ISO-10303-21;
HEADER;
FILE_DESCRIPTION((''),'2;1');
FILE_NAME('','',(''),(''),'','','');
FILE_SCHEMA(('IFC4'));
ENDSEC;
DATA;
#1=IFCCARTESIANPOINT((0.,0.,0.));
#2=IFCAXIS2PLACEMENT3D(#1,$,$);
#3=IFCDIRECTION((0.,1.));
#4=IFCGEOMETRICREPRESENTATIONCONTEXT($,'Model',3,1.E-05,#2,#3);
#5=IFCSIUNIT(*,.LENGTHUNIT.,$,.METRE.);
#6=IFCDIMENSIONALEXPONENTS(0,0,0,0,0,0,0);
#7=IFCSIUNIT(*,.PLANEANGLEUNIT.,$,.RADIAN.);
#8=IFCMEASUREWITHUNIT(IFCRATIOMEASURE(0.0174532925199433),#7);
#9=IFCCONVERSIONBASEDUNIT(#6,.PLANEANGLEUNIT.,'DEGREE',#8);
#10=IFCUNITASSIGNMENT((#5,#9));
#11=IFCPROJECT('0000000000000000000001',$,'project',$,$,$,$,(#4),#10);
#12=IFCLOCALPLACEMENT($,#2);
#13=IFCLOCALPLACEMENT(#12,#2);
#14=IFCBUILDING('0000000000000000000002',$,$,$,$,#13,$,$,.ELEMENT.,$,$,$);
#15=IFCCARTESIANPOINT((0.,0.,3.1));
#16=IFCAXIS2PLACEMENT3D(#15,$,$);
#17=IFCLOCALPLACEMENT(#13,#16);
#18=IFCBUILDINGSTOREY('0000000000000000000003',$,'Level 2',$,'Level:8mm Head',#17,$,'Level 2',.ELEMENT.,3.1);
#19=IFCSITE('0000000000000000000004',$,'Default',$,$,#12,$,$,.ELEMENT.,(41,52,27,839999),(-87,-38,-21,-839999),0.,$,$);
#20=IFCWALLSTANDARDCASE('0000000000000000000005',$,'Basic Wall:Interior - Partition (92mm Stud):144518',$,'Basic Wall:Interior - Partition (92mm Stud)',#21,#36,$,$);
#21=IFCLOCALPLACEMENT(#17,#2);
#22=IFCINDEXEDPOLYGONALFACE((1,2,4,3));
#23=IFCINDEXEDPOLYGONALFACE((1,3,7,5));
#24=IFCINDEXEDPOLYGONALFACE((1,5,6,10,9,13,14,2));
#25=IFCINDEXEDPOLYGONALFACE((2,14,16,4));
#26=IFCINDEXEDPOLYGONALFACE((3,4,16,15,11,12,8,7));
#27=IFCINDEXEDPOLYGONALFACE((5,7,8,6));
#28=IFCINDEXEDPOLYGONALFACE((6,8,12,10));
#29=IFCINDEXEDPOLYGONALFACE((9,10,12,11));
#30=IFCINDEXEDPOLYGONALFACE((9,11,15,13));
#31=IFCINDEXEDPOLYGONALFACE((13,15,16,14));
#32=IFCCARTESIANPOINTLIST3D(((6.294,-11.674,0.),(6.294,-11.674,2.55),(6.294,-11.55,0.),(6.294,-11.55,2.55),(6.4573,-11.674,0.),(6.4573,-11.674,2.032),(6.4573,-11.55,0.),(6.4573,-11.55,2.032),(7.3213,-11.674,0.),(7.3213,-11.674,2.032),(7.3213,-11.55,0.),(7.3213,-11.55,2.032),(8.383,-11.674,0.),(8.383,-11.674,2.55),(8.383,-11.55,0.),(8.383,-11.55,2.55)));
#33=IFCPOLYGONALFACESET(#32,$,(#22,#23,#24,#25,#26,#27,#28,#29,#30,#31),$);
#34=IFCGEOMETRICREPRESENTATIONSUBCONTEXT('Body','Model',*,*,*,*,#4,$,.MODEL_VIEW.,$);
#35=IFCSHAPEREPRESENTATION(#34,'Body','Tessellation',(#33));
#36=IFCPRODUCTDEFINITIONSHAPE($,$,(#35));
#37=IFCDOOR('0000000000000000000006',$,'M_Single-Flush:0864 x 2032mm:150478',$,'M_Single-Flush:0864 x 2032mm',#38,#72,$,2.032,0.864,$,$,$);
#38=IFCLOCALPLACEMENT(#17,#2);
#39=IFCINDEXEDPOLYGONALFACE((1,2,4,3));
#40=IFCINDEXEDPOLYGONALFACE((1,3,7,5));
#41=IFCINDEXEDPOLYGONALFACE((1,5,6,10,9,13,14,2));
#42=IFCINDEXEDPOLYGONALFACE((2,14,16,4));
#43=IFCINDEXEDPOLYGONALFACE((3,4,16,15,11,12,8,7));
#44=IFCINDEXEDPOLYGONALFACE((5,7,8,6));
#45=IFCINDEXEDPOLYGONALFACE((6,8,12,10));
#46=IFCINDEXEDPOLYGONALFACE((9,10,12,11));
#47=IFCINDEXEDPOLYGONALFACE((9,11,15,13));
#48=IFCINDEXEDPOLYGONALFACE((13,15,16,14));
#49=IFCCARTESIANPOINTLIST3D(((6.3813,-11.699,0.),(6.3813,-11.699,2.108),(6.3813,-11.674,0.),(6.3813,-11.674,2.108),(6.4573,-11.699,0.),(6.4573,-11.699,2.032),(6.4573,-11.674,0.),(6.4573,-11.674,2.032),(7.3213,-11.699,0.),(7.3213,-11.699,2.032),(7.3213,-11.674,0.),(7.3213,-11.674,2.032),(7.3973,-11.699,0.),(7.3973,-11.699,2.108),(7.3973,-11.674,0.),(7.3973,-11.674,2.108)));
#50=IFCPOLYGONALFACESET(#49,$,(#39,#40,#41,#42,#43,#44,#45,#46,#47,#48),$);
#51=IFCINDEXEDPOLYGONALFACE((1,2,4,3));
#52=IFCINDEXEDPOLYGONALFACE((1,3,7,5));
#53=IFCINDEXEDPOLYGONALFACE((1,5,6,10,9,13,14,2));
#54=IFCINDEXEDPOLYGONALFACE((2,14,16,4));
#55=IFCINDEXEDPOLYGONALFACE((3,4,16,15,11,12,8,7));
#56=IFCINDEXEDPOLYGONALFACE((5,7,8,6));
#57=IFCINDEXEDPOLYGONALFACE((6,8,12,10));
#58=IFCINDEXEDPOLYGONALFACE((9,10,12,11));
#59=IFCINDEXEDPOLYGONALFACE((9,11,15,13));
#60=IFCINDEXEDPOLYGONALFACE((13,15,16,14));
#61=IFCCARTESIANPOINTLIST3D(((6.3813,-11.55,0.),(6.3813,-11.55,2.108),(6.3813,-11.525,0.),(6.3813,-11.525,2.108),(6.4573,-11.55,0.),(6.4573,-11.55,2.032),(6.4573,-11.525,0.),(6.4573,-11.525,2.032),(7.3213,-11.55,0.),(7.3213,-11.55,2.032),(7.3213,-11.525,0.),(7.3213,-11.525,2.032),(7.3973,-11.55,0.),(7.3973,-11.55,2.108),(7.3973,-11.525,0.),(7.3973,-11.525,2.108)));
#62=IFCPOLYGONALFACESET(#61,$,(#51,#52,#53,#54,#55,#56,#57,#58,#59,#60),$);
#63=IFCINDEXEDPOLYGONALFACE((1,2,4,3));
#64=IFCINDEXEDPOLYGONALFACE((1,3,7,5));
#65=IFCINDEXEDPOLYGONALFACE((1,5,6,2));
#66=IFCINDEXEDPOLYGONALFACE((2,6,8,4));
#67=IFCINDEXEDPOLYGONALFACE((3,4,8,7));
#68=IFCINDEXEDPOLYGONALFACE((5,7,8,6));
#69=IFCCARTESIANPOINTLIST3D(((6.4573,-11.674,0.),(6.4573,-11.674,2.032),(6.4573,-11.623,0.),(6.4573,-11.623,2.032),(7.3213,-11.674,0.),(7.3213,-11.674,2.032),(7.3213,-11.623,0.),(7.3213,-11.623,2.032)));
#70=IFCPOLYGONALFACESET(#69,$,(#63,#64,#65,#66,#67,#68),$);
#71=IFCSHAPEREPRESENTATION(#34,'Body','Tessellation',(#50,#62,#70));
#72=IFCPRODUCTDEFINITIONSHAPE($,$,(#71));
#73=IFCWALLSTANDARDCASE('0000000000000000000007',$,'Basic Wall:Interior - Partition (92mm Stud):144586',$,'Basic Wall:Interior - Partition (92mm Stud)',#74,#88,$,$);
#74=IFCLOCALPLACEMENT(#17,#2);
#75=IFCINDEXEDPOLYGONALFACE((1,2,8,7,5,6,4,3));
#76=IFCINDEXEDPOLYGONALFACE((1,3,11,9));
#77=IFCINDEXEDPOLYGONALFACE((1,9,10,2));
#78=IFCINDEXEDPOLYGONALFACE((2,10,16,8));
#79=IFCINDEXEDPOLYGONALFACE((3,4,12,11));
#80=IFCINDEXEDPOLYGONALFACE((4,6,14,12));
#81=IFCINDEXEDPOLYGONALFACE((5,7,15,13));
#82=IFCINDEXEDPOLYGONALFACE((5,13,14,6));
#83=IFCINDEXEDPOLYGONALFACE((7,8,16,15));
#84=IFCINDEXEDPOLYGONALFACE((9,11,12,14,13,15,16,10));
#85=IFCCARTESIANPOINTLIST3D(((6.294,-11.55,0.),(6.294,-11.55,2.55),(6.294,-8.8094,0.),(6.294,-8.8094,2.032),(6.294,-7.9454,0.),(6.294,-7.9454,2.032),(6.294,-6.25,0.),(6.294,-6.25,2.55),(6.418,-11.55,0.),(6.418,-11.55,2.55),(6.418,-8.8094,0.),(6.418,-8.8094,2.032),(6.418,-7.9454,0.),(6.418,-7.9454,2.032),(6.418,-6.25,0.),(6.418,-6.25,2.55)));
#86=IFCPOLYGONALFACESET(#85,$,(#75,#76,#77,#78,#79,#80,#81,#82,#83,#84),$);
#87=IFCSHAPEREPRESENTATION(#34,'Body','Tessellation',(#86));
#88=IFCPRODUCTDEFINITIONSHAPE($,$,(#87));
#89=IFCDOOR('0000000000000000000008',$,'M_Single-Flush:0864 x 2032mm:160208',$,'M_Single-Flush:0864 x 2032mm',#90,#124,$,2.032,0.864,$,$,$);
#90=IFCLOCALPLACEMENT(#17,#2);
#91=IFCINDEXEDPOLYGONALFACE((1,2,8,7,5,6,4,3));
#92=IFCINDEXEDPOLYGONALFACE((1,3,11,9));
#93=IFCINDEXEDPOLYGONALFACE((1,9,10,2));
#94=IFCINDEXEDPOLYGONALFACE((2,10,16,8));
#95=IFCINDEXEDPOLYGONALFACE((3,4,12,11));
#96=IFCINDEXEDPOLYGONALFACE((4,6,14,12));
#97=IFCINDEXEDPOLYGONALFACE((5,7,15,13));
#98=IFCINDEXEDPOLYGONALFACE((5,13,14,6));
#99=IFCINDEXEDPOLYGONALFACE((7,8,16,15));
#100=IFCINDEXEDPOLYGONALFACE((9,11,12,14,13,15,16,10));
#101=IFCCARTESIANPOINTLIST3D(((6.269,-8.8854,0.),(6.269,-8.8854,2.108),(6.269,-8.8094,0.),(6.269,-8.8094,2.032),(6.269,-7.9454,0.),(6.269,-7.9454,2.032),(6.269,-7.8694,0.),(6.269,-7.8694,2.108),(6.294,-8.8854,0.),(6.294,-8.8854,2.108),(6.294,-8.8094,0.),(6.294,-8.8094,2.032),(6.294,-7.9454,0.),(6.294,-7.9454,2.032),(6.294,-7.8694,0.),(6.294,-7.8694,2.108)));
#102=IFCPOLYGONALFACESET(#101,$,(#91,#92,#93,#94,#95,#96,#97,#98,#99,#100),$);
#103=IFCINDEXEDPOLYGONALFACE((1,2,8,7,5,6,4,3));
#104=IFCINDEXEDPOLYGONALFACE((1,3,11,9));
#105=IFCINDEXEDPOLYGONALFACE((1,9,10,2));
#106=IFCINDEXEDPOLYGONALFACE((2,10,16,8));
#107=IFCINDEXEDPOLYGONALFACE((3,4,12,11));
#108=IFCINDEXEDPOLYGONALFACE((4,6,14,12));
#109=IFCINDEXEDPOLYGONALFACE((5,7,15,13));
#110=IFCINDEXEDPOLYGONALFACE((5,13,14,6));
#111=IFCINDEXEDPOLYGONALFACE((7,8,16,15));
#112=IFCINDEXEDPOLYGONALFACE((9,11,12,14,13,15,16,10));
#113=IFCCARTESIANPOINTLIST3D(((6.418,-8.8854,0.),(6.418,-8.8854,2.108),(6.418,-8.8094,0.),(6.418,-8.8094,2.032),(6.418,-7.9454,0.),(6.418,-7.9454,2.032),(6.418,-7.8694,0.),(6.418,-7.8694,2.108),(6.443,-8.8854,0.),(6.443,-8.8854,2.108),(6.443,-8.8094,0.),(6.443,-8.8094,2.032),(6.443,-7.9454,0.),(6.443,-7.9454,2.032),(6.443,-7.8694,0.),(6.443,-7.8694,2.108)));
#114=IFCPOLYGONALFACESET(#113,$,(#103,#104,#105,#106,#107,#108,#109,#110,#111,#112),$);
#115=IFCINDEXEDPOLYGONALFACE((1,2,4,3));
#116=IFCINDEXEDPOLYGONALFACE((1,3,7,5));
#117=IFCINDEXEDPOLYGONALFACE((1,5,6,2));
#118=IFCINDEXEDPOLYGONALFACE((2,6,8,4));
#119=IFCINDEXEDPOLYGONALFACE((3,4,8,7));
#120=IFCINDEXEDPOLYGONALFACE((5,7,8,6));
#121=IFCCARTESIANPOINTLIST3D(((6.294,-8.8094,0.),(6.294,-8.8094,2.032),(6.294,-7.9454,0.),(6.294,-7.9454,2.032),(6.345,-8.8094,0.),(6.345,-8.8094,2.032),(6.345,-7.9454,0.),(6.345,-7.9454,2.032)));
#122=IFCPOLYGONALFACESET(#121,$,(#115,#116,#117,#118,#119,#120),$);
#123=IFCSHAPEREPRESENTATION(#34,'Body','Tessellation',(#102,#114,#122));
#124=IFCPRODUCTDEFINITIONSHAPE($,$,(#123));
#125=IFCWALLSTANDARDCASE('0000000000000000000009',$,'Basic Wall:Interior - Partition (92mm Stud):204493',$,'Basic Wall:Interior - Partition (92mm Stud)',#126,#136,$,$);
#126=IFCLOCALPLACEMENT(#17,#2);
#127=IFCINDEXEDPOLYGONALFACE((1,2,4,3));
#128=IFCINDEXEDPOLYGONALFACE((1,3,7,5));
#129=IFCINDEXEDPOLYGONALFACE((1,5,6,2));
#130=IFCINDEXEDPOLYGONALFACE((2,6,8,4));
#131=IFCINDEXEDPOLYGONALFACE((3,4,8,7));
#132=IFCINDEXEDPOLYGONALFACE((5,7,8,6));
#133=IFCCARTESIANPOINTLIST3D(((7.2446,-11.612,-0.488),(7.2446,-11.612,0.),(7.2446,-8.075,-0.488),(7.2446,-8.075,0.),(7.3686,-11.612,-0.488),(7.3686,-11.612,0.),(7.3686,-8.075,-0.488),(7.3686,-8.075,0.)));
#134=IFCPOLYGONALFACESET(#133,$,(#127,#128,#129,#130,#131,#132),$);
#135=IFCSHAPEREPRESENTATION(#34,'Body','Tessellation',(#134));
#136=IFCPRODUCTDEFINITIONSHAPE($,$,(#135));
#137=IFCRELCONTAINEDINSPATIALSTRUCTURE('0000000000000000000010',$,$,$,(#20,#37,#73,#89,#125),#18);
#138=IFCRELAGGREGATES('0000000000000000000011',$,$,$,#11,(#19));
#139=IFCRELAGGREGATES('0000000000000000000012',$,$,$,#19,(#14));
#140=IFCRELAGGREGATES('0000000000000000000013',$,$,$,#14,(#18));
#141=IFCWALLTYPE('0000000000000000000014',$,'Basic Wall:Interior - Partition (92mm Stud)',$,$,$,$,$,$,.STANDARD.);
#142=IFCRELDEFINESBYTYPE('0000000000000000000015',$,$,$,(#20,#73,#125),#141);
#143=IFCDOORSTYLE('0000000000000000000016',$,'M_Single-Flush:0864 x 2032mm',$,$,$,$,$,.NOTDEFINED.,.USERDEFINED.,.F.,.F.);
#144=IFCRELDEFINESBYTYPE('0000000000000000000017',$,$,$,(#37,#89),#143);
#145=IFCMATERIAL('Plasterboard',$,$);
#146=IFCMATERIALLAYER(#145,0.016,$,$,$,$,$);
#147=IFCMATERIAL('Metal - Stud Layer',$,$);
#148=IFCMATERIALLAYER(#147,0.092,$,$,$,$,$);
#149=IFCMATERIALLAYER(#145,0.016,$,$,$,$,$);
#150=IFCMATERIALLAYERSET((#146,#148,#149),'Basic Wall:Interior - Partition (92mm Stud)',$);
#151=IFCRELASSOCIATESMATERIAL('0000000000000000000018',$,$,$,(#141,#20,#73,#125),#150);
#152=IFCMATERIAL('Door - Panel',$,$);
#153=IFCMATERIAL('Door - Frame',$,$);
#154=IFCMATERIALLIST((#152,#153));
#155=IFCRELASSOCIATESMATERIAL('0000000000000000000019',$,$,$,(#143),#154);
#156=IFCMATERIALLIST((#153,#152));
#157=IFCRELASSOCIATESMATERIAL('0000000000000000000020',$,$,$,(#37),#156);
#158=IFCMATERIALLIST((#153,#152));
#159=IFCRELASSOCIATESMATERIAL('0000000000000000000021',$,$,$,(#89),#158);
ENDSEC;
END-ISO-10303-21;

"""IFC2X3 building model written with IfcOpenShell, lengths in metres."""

from ifc_helpers import new_model, entity, si_unit, converted_unit, direction, frame, frame_2d, origin, origin_2d_with_axis, place, context, subcontext, project, spatial, polyline, rectangle, outline, extrude, source, transform, mapped, material, material_list, layer, layer_set, layer_usage, type_object, type_shapes, element, fill, save


model = new_model("IFC2X3")

# Units and contexts
model_context = context("Model", 3, precision=1e-05, world=origin(), true_north=direction((0.0, 1.0)))
body_context = subcontext(model_context, "Body", "Model", "MODEL_VIEW")
ifc_project = project(units=[si_unit("LENGTHUNIT", "METRE"), converted_unit("PLANEANGLEUNIT", "DEGREE", entity("IfcRatioMeasure", 0.0174532925199433), si_unit("PLANEANGLEUNIT", "RADIAN"), dimensions=[0, 0, 0, 0, 0, 0, 0])], contexts=[model_context])

# Site, building, storey
site_placement = place(None, origin())
site = spatial("IfcSite", under=ifc_project, at=site_placement, Name="Default", CompositionType="ELEMENT", RefLatitude=(41, 52, 27, 839999), RefLongitude=(-87, -38, -21, -839999), RefElevation=0.0)
building_placement = place(site_placement, origin())
building = spatial("IfcBuilding", under=site, at=building_placement, CompositionType="ELEMENT")
storey_placement = place(building_placement, frame((0.0, 0.0, 3.1)))
storey = spatial("IfcBuildingStorey", under=building, at=storey_placement, Name="Level 2", ObjectType="Level:8mm Head", LongName="Level 2", CompositionType="ELEMENT", Elevation=3.1)

# Shared definitions
ifc_material_1 = material(Name="Metal - Stud Layer")
ifc_material_2 = material(Name="Plasterboard")

# Wall, opening, door
ifc_layer_1 = layer(ifc_material_2, 0.016)
ifc_layer_2 = layer(ifc_material_1, 0.092)
ifc_layer_3 = layer(ifc_material_2, 0.016)
ifc_layer_set_1 = layer_set([ifc_layer_1, ifc_layer_2, ifc_layer_3], Name="Basic Wall:Interior - Partition (92mm Stud)")
ifc_layer_usage_1 = layer_usage(ifc_layer_set_1, "AXIS2", "NEGATIVE", 0.062)
wall_type_1 = type_object("IfcWallType", Name="Basic Wall:Interior - Partition (92mm Stud)", PredefinedType="STANDARD", material=ifc_layer_set_1)
wall_1_placement = place(storey_placement, frame((8.383, -11.612, 0.0), z_axis=(0.0, 0.0, 1.0), x_axis=(-1.0, 0.0, 0.0)))
wall_1 = element("IfcWallStandardCase", 1, at=wall_1_placement, inside=storey, type_object=wall_type_1, material=ifc_layer_usage_1, Name="Basic Wall:Interior - Partition (92mm Stud):144518", ObjectType="Basic Wall:Interior - Partition (92mm Stud)", context=body_context, shape_type="SweptSolid", body=[
    extrude(rectangle(XDim=2.089, YDim=0.124, at=frame_2d((1.0445, 0.0), x_axis=(-1.0, 0.0))), origin(), (0.0, 0.0, 1.0), 2.55),
])
opening_1_placement = place(wall_1_placement, frame((1.0617, -0.062, 0.0)))
opening_1 = element("IfcOpeningElement", 2, at=opening_1_placement, cuts=wall_1, ObjectType="Opening", context=body_context, shape_type="SweptSolid", body=[
    extrude(rectangle(XDim=0.864, YDim=2.032, at=frame_2d((1.016, 0.432), x_axis=(0.0, 1.0))), frame((0.0, 0.0, 0.0), z_axis=(0.0, 1.0, 0.0), x_axis=(0.0, 0.0, 1.0)), (0.0, 0.0, 1.0), 0.124),
])
ifc_material_3 = material(Name="Door - Frame")
ifc_material_4 = material(Name="Door - Panel")
ifc_material_list_1 = material_list([ifc_material_3, ifc_material_4])
ifc_material_list_2 = material_list([ifc_material_4, ifc_material_3])
door_style = type_object("IfcDoorStyle", Name="M_Single-Flush:0864 x 2032mm", ConstructionType="USERDEFINED", OperationType="NOTDEFINED", ParameterTakesPrecedence=False, Sizeable=False, material=ifc_material_list_2)
shared_shape_1 = source(origin(), body_context, "Body", "SweptSolid", [
    extrude(outline(polyline([(-0.508, -1.073), (0.508, -1.073), (0.508, 1.035), (0.432, 1.035), (0.432, -0.997), (-0.432, -0.997), (-0.432, 1.035), (-0.508, 1.035), (-0.508, -1.073)])), frame((0.432, 0.124, 1.035), z_axis=(0.0, 1.0, 0.0), x_axis=(1.0, 0.0, 0.0)), (0.0, 0.0, 1.0), 0.025),
    extrude(outline(polyline([(-1.073, -0.508), (1.035, -0.508), (1.035, -0.432), (-0.997, -0.432), (-0.997, 0.432), (1.035, 0.432), (1.035, 0.508), (-1.073, 0.508), (-1.073, -0.508)])), frame((0.432, -0.025, 1.035), z_axis=(0.0, 1.0, 0.0), x_axis=(0.0, 0.0, -1.0)), (0.0, 0.0, 1.0), 0.025),
    extrude(rectangle(XDim=0.051, YDim=0.864, at=origin_2d_with_axis()), frame((0.432, 0.0985, 0.0), z_axis=(0.0, 0.0, 1.0), x_axis=(0.0, 1.0, 0.0)), (0.0, 0.0, 1.0), 2.032),
])
type_shapes(door_style, [shared_shape_1])
door_1_placement = place(opening_1_placement, origin())
door_1 = element("IfcDoor", 3, at=door_1_placement, inside=storey, type_object=door_style, material=ifc_material_list_1, Name="M_Single-Flush:0864 x 2032mm:150478", ObjectType="M_Single-Flush:0864 x 2032mm", OverallHeight=2.032, OverallWidth=0.864, context=body_context, shape_type="MappedRepresentation", body=[
    mapped(shared_shape_1, transform((0.0, 0.0, 0.0), scale=1.0)),
])
fill(opening_1, door_1)

# Wall, openings, door
ifc_layer_usage_2 = layer_usage(ifc_layer_set_1, "AXIS2", "NEGATIVE", 0.062)
wall_2_placement = place(storey_placement, frame((6.356, -11.55, 0.0), z_axis=(0.0, 0.0, 1.0), x_axis=(0.0, 1.0, 0.0)))
wall_2 = element("IfcWallStandardCase", 4, at=wall_2_placement, inside=storey, type_object=wall_type_1, material=ifc_layer_usage_2, Name="Basic Wall:Interior - Partition (92mm Stud):144586", ObjectType="Basic Wall:Interior - Partition (92mm Stud)", context=body_context, shape_type="SweptSolid", body=[
    extrude(rectangle(XDim=5.3, YDim=0.124, at=frame_2d((2.65, 0.0), x_axis=(-1.0, 0.0))), origin(), (0.0, 0.0, 1.0), 2.55),
])
opening_2_placement = place(wall_2_placement, origin())
element("IfcOpeningElement", 5, at=opening_2_placement, cuts=wall_2, ObjectType="Opening", context=body_context, shape_type="SweptSolid", body=[
    extrude(rectangle(XDim=2.032, YDim=0.124, at=frame_2d((0.0, 0.0), x_axis=(0.0, 1.0))), frame((3.7666, 0.0626, 1.016), z_axis=(0.0, 1.0, 0.0), x_axis=(1.0, 0.0, 0.0)), (0.0, 0.0, 1.0), 0.762),
])
opening_3_placement = place(wall_2_placement, frame((2.7406, -0.062, 0.0)))
opening_3 = element("IfcOpeningElement", 6, at=opening_3_placement, cuts=wall_2, ObjectType="Opening", context=body_context, shape_type="SweptSolid", body=[
    extrude(rectangle(XDim=0.864, YDim=2.032, at=frame_2d((1.016, 0.432), x_axis=(0.0, 1.0))), frame((0.0, 0.0, 0.0), z_axis=(0.0, 1.0, 0.0), x_axis=(0.0, 0.0, 1.0)), (0.0, 0.0, 1.0), 0.124),
])
ifc_material_list_3 = material_list([ifc_material_3, ifc_material_4])
door_2_placement = place(opening_3_placement, origin())
door_2 = element("IfcDoor", 7, at=door_2_placement, inside=storey, type_object=door_style, material=ifc_material_list_3, Name="M_Single-Flush:0864 x 2032mm:160208", ObjectType="M_Single-Flush:0864 x 2032mm", OverallHeight=2.032, OverallWidth=0.864, context=body_context, shape_type="MappedRepresentation", body=[
    mapped(shared_shape_1, transform((0.0, 0.0, 0.0), scale=1.0)),
])
fill(opening_3, door_2)

# Wall
ifc_layer_usage_3 = layer_usage(ifc_layer_set_1, "AXIS2", "NEGATIVE", 0.062)
wall_3_placement = place(storey_placement, frame((7.3066, -11.612, -0.488), z_axis=(0.0, 0.0, 1.0), x_axis=(0.0, 1.0, 0.0)))
element("IfcWallStandardCase", 8, at=wall_3_placement, inside=storey, type_object=wall_type_1, material=ifc_layer_usage_3, Name="Basic Wall:Interior - Partition (92mm Stud):204493", ObjectType="Basic Wall:Interior - Partition (92mm Stud)", context=body_context, shape_type="SweptSolid", body=[
    extrude(rectangle(XDim=3.537, YDim=0.124, at=frame_2d((1.7685, 0.0), x_axis=(-1.0, 0.0))), origin(), (0.0, 0.0, 1.0), 0.488),
])

save(model, "model.ifc")
